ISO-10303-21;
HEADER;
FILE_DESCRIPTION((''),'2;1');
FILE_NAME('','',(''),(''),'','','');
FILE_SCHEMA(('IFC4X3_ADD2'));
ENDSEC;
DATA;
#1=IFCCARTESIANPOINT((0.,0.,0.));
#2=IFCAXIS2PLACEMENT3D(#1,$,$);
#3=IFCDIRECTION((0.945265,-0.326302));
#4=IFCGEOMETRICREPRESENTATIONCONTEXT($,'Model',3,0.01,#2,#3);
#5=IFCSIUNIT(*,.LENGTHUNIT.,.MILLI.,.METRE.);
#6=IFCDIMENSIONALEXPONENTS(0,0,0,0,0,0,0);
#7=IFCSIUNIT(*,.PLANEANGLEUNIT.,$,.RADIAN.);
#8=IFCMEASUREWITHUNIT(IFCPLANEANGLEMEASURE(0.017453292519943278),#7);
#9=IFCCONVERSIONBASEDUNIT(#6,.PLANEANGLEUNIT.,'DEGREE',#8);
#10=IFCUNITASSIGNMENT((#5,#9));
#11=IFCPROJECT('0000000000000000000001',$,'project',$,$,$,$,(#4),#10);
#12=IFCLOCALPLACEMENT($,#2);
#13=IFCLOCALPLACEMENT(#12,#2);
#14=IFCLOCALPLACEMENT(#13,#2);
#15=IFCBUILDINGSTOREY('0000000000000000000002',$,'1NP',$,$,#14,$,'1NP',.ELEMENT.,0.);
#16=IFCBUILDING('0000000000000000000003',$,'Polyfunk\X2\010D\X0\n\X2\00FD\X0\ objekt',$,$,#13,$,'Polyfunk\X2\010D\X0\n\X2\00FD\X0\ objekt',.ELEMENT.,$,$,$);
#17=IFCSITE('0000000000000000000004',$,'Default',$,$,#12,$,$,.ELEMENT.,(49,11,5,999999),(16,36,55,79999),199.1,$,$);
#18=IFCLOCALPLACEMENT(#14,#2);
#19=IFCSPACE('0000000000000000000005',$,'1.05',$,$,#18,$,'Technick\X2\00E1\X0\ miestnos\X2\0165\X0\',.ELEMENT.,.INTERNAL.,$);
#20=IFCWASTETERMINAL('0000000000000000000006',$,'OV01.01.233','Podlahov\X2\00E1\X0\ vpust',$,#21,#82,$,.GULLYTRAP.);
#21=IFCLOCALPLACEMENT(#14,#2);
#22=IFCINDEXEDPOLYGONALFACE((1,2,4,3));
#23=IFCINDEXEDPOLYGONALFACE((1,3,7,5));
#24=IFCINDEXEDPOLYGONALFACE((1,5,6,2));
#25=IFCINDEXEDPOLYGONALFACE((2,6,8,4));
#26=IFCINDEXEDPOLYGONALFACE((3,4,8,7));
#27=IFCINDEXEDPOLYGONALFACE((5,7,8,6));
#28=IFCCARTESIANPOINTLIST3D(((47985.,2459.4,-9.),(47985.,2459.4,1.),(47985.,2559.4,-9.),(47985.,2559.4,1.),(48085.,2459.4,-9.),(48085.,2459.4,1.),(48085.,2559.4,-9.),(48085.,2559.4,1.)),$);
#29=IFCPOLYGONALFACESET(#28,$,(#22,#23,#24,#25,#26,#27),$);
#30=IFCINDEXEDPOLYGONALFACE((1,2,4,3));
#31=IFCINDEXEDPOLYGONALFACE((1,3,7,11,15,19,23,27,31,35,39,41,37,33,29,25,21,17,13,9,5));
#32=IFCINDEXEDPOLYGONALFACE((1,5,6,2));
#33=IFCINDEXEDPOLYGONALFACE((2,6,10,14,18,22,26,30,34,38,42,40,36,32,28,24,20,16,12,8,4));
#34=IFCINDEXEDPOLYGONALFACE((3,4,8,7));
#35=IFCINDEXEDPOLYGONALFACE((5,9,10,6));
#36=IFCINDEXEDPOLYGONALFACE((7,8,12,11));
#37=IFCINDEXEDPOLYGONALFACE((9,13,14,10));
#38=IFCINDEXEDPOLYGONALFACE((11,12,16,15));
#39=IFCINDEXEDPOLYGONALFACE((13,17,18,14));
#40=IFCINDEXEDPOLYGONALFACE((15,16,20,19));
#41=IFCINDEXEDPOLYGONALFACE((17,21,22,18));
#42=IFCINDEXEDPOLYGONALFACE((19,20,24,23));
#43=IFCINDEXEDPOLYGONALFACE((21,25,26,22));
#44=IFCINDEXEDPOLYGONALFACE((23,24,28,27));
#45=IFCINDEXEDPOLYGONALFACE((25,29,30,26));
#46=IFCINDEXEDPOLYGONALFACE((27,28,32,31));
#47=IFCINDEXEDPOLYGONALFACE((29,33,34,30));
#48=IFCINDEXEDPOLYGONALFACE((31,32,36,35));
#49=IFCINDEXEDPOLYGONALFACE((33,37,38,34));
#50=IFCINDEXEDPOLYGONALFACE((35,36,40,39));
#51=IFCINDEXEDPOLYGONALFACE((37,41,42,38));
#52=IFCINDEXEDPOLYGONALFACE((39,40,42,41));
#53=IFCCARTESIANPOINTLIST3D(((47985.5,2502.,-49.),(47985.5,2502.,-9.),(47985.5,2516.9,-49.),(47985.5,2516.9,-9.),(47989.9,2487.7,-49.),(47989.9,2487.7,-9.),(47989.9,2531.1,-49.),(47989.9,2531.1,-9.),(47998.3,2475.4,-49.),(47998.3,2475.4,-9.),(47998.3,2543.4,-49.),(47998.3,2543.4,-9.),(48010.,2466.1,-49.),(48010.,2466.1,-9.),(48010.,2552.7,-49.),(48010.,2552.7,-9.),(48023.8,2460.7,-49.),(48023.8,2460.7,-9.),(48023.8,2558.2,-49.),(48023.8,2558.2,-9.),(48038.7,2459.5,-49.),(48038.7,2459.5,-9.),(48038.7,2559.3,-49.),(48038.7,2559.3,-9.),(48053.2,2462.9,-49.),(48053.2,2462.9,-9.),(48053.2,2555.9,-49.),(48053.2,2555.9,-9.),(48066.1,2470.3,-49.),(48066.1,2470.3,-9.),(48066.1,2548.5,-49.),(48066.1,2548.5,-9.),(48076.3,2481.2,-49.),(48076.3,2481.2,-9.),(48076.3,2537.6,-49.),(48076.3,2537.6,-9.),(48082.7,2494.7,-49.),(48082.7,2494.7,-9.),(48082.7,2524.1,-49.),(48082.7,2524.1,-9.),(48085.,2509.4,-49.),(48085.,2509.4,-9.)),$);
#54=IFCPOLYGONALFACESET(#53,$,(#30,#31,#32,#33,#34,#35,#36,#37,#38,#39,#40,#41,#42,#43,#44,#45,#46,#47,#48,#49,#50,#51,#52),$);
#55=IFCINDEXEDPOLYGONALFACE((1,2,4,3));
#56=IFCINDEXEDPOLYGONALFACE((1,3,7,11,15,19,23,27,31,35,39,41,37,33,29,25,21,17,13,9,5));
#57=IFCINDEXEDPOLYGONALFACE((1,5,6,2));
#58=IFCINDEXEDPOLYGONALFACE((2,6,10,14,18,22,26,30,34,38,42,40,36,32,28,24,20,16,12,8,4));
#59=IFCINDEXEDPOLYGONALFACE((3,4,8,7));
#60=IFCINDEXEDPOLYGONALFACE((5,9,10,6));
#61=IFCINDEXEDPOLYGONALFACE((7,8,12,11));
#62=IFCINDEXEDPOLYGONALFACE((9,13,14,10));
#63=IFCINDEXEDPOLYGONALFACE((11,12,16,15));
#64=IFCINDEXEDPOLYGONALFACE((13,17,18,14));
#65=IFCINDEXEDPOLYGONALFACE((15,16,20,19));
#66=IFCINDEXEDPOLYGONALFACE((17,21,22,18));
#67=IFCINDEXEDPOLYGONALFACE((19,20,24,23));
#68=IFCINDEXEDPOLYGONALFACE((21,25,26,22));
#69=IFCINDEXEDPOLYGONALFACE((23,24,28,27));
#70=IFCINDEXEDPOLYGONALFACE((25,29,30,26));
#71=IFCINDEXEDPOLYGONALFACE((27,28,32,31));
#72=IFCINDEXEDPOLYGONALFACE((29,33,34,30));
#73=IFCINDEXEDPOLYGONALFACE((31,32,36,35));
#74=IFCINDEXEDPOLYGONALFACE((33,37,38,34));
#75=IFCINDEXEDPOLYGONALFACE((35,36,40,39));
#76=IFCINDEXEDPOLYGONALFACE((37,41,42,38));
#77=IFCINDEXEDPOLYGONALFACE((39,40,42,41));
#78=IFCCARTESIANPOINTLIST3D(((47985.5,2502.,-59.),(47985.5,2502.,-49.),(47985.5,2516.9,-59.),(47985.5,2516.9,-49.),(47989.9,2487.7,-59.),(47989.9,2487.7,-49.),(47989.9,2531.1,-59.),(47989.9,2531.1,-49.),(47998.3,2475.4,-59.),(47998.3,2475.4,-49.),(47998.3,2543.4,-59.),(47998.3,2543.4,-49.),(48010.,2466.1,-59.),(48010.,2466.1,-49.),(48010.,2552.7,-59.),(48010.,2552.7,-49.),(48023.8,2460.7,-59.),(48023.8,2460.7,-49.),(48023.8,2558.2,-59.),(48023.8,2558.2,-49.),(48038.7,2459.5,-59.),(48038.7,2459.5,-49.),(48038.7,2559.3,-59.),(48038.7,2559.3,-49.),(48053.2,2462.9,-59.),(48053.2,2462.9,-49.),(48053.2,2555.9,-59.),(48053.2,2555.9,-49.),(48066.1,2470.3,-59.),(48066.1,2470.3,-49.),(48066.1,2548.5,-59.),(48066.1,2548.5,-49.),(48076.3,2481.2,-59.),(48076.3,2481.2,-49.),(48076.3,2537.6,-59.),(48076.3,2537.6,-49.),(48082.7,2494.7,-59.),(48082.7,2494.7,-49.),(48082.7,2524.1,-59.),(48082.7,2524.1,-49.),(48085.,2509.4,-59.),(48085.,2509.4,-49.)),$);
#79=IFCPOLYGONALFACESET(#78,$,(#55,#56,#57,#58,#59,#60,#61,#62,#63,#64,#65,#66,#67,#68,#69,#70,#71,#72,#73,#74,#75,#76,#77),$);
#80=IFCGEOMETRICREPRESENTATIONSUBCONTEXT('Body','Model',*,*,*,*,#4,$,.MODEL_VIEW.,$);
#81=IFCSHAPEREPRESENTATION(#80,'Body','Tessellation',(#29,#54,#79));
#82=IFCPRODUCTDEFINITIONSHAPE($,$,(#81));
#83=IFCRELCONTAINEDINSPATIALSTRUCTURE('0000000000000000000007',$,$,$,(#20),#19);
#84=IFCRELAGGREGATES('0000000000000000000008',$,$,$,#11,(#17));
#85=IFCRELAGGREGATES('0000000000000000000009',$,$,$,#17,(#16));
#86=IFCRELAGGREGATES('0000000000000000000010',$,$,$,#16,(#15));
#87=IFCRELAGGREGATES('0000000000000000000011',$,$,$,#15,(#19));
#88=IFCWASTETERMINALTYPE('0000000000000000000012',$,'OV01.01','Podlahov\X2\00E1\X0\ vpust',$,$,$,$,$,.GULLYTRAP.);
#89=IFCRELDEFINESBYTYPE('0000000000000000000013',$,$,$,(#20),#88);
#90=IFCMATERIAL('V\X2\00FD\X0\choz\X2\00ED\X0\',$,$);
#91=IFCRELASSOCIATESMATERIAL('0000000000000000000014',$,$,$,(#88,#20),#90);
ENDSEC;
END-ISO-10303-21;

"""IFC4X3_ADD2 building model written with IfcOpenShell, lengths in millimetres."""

from ifc_helpers import new_model, entity, si_unit, converted_unit, direction, frame, frame_2d, origin, place, context, subcontext, project, spatial, rectangle, circle, extrude, source, transform, mapped, material, type_object, type_shapes, element, save


model = new_model("IFC4X3_ADD2")

# Units and contexts
model_context = context("Model", 3, precision=0.01, world=origin(), true_north=direction((0.945265, -0.326302)))
body_context = subcontext(model_context, "Body", "Model", "MODEL_VIEW")
ifc_project = project(units=[si_unit("LENGTHUNIT", "METRE", prefix="MILLI"), converted_unit("PLANEANGLEUNIT", "DEGREE", entity("IfcPlaneAngleMeasure", 0.017453292519943278), si_unit("PLANEANGLEUNIT", "RADIAN"), dimensions=[0, 0, 0, 0, 0, 0, 0])], contexts=[model_context])

# Site, building, storey
site_placement = place(None, origin())
site = spatial("IfcSite", under=ifc_project, at=site_placement, Name="Default", CompositionType="ELEMENT", RefLatitude=(49, 11, 5, 999999), RefLongitude=(16, 36, 55, 79999), RefElevation=199.1)
building_placement = place(site_placement, origin())
building = spatial("IfcBuilding", under=site, at=building_placement, Name="Polyfunkčný objekt", LongName="Polyfunkčný objekt", CompositionType="ELEMENT")
storey_placement = place(building_placement, origin())
storey = spatial("IfcBuildingStorey", under=building, at=storey_placement, Name="1NP", LongName="1NP", CompositionType="ELEMENT", Elevation=0.0)

# Shared definitions
space_1_placement = place(storey_placement, origin())
space_1 = spatial("IfcSpace", under=storey, at=space_1_placement, Name="1.05", LongName="Technická miestnosť", CompositionType="ELEMENT", PredefinedType="INTERNAL")

# Waste terminal
ifc_material_1 = material(Name="Výchozí")
waste_terminal_type = type_object("IfcWasteTerminalType", Name="OV01.01", Description="Podlahová vpust", PredefinedType="GULLYTRAP", material=ifc_material_1)
shared_shape_1 = source(origin(), body_context, "Body", "SweptSolid", [
    extrude(rectangle(XDim=100.0, YDim=100.0, at=frame_2d((0.0, 0.0), x_axis=(1.0, 0.0))), frame((0.0, 0.0, -10.0), z_axis=(0.0, 0.0, 1.0), x_axis=(-1.0, 0.0, 0.0)), (0.0, 0.0, 1.0), 10.0),
    extrude(circle(Radius=50.0, at=frame_2d((0.0, 0.0), x_axis=(1.0, 0.0))), frame((0.0, 0.0, -50.0)), (0.0, 0.0, 1.0), 40.0),
    extrude(circle(Radius=50.0, at=frame_2d((0.0, 0.0), x_axis=(1.0, 0.0))), frame((0.0, 0.0, -60.0)), (0.0, 0.0, 1.0), 10.0),
])
type_shapes(waste_terminal_type, [shared_shape_1])
waste_terminal_placement = place(storey_placement, frame((48035.0, 2509.4, 1.0)))
element("IfcWasteTerminal", 1, at=waste_terminal_placement, inside=space_1, type_object=waste_terminal_type, material=ifc_material_1, Name="OV01.01.233", Description="Podlahová vpust", PredefinedType="GULLYTRAP", context=body_context, shape_type="MappedRepresentation", body=[
    mapped(shared_shape_1, transform((0.0, 0.0, 0.0), scale=1.0)),
])

save(model, "model.ifc")
